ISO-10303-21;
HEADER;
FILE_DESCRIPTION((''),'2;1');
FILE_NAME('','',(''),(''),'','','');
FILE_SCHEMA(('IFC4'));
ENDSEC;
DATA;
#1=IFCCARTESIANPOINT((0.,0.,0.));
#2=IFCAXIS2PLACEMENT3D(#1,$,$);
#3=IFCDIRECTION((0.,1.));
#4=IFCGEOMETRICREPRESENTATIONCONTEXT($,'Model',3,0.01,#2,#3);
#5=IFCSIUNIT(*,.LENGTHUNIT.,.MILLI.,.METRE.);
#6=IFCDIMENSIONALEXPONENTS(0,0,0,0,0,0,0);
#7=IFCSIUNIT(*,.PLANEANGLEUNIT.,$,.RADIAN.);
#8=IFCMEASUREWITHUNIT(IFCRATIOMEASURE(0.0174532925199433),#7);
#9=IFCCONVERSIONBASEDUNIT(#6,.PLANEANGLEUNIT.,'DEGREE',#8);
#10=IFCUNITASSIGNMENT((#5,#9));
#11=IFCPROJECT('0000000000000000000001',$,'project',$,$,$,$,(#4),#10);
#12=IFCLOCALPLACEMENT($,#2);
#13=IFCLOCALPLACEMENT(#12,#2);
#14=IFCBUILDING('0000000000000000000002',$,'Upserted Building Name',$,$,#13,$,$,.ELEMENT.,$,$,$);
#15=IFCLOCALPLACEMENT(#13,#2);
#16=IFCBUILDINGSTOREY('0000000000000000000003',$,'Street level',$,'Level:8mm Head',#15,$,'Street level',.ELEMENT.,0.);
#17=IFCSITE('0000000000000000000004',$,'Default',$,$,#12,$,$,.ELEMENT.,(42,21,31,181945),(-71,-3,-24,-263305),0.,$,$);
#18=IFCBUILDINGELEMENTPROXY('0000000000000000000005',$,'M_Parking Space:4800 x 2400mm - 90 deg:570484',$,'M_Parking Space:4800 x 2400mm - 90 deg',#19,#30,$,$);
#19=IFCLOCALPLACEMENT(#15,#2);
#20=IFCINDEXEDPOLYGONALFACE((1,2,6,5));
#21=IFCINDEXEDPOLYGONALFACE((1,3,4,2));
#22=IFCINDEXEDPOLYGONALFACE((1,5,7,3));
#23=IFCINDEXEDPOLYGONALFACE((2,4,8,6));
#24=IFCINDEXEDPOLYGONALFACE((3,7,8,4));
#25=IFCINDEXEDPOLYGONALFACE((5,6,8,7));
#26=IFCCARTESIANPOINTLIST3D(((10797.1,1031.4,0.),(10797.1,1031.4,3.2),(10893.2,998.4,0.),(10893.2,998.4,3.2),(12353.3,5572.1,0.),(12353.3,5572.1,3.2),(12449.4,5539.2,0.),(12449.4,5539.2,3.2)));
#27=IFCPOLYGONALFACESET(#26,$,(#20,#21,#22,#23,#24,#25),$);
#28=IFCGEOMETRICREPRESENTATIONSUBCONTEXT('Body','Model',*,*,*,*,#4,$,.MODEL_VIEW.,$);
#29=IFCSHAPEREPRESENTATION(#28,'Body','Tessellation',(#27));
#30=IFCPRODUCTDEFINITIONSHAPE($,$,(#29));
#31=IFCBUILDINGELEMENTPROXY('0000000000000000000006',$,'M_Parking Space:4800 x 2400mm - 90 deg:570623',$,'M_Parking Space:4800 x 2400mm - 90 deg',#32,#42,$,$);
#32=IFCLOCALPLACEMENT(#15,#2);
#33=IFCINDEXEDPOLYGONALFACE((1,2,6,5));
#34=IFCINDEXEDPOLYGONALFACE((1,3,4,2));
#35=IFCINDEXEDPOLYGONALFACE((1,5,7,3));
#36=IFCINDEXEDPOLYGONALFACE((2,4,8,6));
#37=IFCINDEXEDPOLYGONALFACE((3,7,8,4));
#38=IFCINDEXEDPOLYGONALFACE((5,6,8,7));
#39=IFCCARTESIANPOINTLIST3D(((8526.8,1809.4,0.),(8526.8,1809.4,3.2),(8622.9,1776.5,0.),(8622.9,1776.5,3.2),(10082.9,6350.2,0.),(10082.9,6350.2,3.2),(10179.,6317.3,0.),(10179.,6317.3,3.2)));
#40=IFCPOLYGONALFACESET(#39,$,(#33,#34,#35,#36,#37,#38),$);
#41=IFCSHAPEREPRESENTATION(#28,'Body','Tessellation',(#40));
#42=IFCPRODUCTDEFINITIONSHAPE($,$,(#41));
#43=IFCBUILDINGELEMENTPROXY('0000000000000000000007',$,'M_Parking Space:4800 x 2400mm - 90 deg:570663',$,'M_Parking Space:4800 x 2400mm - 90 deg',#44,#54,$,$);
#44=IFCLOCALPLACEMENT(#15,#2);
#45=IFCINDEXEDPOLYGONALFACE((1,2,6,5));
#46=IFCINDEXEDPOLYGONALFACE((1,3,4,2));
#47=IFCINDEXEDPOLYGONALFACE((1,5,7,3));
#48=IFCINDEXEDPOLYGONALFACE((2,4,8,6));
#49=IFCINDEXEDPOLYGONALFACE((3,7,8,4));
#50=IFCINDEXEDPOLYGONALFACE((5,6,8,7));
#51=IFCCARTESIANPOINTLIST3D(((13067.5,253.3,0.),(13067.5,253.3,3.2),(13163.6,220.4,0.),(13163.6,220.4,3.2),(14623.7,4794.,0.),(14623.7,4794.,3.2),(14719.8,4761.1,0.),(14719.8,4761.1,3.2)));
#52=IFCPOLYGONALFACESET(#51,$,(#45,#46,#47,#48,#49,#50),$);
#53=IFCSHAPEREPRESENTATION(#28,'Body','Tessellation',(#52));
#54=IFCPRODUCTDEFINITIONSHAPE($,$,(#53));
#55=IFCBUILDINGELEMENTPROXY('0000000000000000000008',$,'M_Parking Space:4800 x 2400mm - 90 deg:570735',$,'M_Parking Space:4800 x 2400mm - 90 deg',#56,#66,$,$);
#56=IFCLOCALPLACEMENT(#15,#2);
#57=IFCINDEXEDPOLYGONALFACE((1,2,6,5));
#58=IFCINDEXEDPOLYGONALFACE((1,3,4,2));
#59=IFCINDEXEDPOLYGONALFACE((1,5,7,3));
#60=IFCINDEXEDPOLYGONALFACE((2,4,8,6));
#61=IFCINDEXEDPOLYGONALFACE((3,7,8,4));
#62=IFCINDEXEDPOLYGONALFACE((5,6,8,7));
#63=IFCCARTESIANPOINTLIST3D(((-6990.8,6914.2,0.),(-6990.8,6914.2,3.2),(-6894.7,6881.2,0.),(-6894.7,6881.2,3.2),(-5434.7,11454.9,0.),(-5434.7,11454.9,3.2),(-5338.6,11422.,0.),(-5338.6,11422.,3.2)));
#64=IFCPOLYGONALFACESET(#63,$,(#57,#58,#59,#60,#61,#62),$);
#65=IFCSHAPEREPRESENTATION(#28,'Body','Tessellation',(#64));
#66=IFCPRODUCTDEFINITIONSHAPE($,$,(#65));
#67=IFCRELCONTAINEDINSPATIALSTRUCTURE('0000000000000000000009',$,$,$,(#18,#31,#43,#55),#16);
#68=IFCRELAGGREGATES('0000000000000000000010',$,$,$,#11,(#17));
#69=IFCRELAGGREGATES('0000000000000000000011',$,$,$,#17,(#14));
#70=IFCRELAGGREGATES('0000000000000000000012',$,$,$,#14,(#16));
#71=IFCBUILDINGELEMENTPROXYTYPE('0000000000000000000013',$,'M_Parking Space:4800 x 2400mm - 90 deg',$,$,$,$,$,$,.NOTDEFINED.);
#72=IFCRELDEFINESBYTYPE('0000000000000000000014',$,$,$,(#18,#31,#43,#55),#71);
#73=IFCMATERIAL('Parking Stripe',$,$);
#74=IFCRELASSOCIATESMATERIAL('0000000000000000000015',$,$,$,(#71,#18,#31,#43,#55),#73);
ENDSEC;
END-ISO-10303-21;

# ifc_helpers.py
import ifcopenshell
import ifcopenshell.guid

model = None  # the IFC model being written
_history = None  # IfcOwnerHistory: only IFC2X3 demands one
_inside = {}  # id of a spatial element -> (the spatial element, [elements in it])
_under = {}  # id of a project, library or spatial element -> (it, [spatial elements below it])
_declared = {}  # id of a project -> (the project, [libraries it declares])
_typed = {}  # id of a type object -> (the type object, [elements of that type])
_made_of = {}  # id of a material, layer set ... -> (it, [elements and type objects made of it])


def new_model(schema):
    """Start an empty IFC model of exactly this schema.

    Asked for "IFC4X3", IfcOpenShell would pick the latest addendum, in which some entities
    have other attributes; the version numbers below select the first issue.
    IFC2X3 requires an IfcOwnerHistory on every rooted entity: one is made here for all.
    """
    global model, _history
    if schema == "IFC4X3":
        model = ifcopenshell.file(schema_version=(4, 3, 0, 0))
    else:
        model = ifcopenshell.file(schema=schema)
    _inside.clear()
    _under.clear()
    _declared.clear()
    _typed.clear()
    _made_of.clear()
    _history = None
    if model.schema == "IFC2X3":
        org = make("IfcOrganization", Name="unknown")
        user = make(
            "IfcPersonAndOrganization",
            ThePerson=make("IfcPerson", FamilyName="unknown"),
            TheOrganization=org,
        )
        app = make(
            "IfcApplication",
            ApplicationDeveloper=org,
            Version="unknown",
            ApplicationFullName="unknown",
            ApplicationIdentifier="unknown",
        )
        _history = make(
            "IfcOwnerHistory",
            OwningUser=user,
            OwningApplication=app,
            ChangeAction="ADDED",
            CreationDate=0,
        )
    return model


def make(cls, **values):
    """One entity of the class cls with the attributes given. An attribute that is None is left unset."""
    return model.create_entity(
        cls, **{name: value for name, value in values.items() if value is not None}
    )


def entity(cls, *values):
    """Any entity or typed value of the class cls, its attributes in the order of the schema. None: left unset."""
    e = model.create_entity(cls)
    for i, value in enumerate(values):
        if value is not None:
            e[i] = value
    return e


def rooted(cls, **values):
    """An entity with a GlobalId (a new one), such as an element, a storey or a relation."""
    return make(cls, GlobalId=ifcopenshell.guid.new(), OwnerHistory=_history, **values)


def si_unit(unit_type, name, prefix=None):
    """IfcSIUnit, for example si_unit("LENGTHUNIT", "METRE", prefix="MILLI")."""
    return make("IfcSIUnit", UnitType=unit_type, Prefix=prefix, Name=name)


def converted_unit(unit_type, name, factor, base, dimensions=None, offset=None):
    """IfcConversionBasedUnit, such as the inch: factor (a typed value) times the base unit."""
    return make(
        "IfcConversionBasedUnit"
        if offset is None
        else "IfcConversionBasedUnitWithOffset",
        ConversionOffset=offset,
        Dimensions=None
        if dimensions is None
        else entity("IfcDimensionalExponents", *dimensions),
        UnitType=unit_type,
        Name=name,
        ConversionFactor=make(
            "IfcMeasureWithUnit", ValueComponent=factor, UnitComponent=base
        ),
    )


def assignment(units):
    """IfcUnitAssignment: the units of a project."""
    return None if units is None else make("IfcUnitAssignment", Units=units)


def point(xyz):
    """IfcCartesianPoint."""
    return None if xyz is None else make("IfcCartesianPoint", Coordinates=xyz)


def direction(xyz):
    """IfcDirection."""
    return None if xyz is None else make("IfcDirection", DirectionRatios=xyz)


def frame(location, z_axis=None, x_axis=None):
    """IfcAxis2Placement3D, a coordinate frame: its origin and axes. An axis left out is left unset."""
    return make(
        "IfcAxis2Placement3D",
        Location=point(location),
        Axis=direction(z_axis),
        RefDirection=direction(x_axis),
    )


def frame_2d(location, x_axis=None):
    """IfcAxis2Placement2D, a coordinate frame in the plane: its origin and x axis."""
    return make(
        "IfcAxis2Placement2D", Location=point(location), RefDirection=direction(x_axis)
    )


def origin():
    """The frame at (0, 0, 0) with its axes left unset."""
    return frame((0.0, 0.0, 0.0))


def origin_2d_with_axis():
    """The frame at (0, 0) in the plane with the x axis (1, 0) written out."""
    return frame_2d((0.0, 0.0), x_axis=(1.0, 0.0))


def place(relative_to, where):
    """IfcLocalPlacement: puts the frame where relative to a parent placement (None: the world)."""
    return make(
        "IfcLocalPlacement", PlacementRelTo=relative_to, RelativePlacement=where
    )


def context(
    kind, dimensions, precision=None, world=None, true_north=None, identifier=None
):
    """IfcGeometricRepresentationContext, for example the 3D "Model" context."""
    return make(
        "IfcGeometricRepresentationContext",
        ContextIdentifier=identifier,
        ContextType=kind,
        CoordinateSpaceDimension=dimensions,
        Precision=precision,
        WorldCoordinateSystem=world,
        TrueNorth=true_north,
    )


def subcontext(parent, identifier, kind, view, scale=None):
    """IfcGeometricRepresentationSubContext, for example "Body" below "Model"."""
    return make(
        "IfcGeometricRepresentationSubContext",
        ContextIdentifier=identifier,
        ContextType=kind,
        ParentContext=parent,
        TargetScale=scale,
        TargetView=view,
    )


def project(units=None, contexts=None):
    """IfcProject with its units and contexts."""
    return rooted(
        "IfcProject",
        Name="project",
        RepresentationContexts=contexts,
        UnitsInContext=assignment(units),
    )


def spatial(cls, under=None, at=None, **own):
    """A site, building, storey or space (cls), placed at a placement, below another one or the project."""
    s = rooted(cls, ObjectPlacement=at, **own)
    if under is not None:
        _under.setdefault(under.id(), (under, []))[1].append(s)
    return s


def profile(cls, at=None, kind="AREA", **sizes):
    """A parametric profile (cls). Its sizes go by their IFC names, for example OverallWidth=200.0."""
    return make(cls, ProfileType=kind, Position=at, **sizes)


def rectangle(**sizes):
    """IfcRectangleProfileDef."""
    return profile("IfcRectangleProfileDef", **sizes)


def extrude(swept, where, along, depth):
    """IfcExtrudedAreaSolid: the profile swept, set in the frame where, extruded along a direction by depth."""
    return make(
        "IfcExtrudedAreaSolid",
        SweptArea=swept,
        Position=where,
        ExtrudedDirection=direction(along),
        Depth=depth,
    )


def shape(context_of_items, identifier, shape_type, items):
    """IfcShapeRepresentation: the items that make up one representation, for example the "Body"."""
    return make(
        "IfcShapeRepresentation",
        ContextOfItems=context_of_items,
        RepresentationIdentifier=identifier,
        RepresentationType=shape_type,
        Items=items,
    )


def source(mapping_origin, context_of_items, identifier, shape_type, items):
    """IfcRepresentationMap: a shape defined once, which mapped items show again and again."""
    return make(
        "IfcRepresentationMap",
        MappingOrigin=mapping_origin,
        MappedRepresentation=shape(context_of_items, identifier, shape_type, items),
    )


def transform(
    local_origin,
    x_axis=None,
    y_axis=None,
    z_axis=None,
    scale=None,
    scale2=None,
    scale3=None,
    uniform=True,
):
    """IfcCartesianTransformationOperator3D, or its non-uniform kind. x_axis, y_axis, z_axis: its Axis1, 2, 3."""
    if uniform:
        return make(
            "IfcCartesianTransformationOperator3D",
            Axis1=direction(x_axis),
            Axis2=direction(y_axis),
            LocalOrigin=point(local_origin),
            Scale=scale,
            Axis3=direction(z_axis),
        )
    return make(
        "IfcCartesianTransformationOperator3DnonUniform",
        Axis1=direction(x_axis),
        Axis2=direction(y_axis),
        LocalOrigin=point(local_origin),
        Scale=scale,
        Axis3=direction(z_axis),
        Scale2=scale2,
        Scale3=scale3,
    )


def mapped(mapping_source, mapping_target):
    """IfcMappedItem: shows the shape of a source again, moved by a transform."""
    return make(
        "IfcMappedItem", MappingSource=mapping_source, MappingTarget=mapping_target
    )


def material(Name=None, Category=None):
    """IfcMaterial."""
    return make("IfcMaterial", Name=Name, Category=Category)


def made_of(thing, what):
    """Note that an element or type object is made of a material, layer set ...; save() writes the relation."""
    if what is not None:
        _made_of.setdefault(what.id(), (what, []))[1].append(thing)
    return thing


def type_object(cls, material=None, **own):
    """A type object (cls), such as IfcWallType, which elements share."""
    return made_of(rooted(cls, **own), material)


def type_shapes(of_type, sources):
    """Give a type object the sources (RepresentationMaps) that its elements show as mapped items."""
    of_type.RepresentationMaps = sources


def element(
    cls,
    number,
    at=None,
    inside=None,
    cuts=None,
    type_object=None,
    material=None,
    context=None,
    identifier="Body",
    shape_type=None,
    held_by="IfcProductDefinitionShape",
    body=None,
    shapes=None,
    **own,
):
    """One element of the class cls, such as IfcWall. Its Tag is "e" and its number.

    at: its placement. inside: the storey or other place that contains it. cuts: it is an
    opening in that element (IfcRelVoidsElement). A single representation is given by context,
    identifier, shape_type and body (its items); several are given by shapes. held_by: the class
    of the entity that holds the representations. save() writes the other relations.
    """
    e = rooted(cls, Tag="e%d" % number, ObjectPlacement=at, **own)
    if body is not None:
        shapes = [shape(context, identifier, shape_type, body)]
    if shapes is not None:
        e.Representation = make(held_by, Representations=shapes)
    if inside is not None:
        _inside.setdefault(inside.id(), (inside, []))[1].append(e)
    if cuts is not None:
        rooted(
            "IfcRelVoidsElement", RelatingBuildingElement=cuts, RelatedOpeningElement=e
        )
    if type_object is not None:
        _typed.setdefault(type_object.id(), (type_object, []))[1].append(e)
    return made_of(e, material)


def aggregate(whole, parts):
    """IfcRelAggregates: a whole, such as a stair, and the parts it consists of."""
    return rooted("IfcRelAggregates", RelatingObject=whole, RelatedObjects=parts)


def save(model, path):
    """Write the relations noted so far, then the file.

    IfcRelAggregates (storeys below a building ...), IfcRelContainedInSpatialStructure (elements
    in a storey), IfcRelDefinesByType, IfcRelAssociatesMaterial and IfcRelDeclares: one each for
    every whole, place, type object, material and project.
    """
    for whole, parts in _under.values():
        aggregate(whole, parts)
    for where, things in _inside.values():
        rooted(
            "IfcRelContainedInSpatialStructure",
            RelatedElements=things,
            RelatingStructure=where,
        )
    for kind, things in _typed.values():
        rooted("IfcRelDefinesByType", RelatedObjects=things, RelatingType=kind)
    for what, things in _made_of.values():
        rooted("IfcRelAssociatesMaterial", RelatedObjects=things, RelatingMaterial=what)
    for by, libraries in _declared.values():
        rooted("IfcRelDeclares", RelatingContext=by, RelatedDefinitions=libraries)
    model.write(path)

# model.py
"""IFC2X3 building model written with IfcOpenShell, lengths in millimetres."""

from ifc_helpers import new_model, entity, si_unit, converted_unit, direction, frame, origin, origin_2d_with_axis, place, context, subcontext, project, spatial, rectangle, extrude, source, transform, mapped, material, type_object, type_shapes, element, save


model = new_model("IFC2X3")

# Units and contexts
model_context = context("Model", 3, precision=0.01, world=origin(), true_north=direction((0.0, 1.0)))
body_context = subcontext(model_context, "Body", "Model", "MODEL_VIEW")
ifc_project = project(units=[si_unit("LENGTHUNIT", "METRE", prefix="MILLI"), converted_unit("PLANEANGLEUNIT", "DEGREE", entity("IfcRatioMeasure", 0.0174532925199433), si_unit("PLANEANGLEUNIT", "RADIAN"), dimensions=[0, 0, 0, 0, 0, 0, 0])], contexts=[model_context])

# Site, building, storey
site_placement = place(None, origin())
site = spatial("IfcSite", under=ifc_project, at=site_placement, Name="Default", CompositionType="ELEMENT", RefLatitude=(42, 21, 31, 181945), RefLongitude=(-71, -3, -24, -263305), RefElevation=0.0)
building_placement = place(site_placement, origin())
building = spatial("IfcBuilding", under=site, at=building_placement, Name="Upserted Building Name", CompositionType="ELEMENT")
storey_placement = place(building_placement, origin())
storey = spatial("IfcBuildingStorey", under=building, at=storey_placement, Name="Street level", ObjectType="Level:8mm Head", LongName="Street level", CompositionType="ELEMENT", Elevation=0.0)

# Building element proxies
ifc_material_1 = material(Name="Parking Stripe")
building_element_proxy_type = type_object("IfcBuildingElementProxyType", Name="M_Parking Space:4800 x 2400mm - 90 deg", PredefinedType="NOTDEFINED", material=ifc_material_1)
shared_shape_1 = source(origin(), body_context, "Body", "SweptSolid", [
    extrude(rectangle(XDim=101.6, YDim=4800.0, at=origin_2d_with_axis()), frame((0.0, 2400.0, 0.0)), (0.0, 0.0, 1.0), 3.2),
])
type_shapes(building_element_proxy_type, [shared_shape_1])
for number, where, z_axis, x_axis, name in (
    (1, (10845.2, 1014.9, 0.0), (0.0, 0.0, 1.0), (0.945989, -0.324198, 0.0), "M_Parking Space:4800 x 2400mm - 90 deg:570484"),
    (2, (8574.8, 1793.0, 0.0), (0.0, 0.0, 1.0), (0.945989, -0.324198, 0.0), "M_Parking Space:4800 x 2400mm - 90 deg:570623"),
    (3, (13115.6, 236.8, 0.0), (0.0, 0.0, 1.0), (0.945989, -0.324198, 0.0), "M_Parking Space:4800 x 2400mm - 90 deg:570663"),
    (4, (-6942.8, 6897.7, 0.0), (0.0, 0.0, 1.0), (0.945989, -0.324198, 0.0), "M_Parking Space:4800 x 2400mm - 90 deg:570735"),
):
    element("IfcBuildingElementProxy", number, at=place(storey_placement, frame(where, z_axis=z_axis, x_axis=x_axis)), inside=storey, type_object=building_element_proxy_type, material=ifc_material_1, Name=name, ObjectType="M_Parking Space:4800 x 2400mm - 90 deg", context=body_context, shape_type="MappedRepresentation", body=[
        mapped(shared_shape_1, transform((0.0, 0.0, 0.0), scale=1.0)),
    ])

save(model, "model.ifc")
